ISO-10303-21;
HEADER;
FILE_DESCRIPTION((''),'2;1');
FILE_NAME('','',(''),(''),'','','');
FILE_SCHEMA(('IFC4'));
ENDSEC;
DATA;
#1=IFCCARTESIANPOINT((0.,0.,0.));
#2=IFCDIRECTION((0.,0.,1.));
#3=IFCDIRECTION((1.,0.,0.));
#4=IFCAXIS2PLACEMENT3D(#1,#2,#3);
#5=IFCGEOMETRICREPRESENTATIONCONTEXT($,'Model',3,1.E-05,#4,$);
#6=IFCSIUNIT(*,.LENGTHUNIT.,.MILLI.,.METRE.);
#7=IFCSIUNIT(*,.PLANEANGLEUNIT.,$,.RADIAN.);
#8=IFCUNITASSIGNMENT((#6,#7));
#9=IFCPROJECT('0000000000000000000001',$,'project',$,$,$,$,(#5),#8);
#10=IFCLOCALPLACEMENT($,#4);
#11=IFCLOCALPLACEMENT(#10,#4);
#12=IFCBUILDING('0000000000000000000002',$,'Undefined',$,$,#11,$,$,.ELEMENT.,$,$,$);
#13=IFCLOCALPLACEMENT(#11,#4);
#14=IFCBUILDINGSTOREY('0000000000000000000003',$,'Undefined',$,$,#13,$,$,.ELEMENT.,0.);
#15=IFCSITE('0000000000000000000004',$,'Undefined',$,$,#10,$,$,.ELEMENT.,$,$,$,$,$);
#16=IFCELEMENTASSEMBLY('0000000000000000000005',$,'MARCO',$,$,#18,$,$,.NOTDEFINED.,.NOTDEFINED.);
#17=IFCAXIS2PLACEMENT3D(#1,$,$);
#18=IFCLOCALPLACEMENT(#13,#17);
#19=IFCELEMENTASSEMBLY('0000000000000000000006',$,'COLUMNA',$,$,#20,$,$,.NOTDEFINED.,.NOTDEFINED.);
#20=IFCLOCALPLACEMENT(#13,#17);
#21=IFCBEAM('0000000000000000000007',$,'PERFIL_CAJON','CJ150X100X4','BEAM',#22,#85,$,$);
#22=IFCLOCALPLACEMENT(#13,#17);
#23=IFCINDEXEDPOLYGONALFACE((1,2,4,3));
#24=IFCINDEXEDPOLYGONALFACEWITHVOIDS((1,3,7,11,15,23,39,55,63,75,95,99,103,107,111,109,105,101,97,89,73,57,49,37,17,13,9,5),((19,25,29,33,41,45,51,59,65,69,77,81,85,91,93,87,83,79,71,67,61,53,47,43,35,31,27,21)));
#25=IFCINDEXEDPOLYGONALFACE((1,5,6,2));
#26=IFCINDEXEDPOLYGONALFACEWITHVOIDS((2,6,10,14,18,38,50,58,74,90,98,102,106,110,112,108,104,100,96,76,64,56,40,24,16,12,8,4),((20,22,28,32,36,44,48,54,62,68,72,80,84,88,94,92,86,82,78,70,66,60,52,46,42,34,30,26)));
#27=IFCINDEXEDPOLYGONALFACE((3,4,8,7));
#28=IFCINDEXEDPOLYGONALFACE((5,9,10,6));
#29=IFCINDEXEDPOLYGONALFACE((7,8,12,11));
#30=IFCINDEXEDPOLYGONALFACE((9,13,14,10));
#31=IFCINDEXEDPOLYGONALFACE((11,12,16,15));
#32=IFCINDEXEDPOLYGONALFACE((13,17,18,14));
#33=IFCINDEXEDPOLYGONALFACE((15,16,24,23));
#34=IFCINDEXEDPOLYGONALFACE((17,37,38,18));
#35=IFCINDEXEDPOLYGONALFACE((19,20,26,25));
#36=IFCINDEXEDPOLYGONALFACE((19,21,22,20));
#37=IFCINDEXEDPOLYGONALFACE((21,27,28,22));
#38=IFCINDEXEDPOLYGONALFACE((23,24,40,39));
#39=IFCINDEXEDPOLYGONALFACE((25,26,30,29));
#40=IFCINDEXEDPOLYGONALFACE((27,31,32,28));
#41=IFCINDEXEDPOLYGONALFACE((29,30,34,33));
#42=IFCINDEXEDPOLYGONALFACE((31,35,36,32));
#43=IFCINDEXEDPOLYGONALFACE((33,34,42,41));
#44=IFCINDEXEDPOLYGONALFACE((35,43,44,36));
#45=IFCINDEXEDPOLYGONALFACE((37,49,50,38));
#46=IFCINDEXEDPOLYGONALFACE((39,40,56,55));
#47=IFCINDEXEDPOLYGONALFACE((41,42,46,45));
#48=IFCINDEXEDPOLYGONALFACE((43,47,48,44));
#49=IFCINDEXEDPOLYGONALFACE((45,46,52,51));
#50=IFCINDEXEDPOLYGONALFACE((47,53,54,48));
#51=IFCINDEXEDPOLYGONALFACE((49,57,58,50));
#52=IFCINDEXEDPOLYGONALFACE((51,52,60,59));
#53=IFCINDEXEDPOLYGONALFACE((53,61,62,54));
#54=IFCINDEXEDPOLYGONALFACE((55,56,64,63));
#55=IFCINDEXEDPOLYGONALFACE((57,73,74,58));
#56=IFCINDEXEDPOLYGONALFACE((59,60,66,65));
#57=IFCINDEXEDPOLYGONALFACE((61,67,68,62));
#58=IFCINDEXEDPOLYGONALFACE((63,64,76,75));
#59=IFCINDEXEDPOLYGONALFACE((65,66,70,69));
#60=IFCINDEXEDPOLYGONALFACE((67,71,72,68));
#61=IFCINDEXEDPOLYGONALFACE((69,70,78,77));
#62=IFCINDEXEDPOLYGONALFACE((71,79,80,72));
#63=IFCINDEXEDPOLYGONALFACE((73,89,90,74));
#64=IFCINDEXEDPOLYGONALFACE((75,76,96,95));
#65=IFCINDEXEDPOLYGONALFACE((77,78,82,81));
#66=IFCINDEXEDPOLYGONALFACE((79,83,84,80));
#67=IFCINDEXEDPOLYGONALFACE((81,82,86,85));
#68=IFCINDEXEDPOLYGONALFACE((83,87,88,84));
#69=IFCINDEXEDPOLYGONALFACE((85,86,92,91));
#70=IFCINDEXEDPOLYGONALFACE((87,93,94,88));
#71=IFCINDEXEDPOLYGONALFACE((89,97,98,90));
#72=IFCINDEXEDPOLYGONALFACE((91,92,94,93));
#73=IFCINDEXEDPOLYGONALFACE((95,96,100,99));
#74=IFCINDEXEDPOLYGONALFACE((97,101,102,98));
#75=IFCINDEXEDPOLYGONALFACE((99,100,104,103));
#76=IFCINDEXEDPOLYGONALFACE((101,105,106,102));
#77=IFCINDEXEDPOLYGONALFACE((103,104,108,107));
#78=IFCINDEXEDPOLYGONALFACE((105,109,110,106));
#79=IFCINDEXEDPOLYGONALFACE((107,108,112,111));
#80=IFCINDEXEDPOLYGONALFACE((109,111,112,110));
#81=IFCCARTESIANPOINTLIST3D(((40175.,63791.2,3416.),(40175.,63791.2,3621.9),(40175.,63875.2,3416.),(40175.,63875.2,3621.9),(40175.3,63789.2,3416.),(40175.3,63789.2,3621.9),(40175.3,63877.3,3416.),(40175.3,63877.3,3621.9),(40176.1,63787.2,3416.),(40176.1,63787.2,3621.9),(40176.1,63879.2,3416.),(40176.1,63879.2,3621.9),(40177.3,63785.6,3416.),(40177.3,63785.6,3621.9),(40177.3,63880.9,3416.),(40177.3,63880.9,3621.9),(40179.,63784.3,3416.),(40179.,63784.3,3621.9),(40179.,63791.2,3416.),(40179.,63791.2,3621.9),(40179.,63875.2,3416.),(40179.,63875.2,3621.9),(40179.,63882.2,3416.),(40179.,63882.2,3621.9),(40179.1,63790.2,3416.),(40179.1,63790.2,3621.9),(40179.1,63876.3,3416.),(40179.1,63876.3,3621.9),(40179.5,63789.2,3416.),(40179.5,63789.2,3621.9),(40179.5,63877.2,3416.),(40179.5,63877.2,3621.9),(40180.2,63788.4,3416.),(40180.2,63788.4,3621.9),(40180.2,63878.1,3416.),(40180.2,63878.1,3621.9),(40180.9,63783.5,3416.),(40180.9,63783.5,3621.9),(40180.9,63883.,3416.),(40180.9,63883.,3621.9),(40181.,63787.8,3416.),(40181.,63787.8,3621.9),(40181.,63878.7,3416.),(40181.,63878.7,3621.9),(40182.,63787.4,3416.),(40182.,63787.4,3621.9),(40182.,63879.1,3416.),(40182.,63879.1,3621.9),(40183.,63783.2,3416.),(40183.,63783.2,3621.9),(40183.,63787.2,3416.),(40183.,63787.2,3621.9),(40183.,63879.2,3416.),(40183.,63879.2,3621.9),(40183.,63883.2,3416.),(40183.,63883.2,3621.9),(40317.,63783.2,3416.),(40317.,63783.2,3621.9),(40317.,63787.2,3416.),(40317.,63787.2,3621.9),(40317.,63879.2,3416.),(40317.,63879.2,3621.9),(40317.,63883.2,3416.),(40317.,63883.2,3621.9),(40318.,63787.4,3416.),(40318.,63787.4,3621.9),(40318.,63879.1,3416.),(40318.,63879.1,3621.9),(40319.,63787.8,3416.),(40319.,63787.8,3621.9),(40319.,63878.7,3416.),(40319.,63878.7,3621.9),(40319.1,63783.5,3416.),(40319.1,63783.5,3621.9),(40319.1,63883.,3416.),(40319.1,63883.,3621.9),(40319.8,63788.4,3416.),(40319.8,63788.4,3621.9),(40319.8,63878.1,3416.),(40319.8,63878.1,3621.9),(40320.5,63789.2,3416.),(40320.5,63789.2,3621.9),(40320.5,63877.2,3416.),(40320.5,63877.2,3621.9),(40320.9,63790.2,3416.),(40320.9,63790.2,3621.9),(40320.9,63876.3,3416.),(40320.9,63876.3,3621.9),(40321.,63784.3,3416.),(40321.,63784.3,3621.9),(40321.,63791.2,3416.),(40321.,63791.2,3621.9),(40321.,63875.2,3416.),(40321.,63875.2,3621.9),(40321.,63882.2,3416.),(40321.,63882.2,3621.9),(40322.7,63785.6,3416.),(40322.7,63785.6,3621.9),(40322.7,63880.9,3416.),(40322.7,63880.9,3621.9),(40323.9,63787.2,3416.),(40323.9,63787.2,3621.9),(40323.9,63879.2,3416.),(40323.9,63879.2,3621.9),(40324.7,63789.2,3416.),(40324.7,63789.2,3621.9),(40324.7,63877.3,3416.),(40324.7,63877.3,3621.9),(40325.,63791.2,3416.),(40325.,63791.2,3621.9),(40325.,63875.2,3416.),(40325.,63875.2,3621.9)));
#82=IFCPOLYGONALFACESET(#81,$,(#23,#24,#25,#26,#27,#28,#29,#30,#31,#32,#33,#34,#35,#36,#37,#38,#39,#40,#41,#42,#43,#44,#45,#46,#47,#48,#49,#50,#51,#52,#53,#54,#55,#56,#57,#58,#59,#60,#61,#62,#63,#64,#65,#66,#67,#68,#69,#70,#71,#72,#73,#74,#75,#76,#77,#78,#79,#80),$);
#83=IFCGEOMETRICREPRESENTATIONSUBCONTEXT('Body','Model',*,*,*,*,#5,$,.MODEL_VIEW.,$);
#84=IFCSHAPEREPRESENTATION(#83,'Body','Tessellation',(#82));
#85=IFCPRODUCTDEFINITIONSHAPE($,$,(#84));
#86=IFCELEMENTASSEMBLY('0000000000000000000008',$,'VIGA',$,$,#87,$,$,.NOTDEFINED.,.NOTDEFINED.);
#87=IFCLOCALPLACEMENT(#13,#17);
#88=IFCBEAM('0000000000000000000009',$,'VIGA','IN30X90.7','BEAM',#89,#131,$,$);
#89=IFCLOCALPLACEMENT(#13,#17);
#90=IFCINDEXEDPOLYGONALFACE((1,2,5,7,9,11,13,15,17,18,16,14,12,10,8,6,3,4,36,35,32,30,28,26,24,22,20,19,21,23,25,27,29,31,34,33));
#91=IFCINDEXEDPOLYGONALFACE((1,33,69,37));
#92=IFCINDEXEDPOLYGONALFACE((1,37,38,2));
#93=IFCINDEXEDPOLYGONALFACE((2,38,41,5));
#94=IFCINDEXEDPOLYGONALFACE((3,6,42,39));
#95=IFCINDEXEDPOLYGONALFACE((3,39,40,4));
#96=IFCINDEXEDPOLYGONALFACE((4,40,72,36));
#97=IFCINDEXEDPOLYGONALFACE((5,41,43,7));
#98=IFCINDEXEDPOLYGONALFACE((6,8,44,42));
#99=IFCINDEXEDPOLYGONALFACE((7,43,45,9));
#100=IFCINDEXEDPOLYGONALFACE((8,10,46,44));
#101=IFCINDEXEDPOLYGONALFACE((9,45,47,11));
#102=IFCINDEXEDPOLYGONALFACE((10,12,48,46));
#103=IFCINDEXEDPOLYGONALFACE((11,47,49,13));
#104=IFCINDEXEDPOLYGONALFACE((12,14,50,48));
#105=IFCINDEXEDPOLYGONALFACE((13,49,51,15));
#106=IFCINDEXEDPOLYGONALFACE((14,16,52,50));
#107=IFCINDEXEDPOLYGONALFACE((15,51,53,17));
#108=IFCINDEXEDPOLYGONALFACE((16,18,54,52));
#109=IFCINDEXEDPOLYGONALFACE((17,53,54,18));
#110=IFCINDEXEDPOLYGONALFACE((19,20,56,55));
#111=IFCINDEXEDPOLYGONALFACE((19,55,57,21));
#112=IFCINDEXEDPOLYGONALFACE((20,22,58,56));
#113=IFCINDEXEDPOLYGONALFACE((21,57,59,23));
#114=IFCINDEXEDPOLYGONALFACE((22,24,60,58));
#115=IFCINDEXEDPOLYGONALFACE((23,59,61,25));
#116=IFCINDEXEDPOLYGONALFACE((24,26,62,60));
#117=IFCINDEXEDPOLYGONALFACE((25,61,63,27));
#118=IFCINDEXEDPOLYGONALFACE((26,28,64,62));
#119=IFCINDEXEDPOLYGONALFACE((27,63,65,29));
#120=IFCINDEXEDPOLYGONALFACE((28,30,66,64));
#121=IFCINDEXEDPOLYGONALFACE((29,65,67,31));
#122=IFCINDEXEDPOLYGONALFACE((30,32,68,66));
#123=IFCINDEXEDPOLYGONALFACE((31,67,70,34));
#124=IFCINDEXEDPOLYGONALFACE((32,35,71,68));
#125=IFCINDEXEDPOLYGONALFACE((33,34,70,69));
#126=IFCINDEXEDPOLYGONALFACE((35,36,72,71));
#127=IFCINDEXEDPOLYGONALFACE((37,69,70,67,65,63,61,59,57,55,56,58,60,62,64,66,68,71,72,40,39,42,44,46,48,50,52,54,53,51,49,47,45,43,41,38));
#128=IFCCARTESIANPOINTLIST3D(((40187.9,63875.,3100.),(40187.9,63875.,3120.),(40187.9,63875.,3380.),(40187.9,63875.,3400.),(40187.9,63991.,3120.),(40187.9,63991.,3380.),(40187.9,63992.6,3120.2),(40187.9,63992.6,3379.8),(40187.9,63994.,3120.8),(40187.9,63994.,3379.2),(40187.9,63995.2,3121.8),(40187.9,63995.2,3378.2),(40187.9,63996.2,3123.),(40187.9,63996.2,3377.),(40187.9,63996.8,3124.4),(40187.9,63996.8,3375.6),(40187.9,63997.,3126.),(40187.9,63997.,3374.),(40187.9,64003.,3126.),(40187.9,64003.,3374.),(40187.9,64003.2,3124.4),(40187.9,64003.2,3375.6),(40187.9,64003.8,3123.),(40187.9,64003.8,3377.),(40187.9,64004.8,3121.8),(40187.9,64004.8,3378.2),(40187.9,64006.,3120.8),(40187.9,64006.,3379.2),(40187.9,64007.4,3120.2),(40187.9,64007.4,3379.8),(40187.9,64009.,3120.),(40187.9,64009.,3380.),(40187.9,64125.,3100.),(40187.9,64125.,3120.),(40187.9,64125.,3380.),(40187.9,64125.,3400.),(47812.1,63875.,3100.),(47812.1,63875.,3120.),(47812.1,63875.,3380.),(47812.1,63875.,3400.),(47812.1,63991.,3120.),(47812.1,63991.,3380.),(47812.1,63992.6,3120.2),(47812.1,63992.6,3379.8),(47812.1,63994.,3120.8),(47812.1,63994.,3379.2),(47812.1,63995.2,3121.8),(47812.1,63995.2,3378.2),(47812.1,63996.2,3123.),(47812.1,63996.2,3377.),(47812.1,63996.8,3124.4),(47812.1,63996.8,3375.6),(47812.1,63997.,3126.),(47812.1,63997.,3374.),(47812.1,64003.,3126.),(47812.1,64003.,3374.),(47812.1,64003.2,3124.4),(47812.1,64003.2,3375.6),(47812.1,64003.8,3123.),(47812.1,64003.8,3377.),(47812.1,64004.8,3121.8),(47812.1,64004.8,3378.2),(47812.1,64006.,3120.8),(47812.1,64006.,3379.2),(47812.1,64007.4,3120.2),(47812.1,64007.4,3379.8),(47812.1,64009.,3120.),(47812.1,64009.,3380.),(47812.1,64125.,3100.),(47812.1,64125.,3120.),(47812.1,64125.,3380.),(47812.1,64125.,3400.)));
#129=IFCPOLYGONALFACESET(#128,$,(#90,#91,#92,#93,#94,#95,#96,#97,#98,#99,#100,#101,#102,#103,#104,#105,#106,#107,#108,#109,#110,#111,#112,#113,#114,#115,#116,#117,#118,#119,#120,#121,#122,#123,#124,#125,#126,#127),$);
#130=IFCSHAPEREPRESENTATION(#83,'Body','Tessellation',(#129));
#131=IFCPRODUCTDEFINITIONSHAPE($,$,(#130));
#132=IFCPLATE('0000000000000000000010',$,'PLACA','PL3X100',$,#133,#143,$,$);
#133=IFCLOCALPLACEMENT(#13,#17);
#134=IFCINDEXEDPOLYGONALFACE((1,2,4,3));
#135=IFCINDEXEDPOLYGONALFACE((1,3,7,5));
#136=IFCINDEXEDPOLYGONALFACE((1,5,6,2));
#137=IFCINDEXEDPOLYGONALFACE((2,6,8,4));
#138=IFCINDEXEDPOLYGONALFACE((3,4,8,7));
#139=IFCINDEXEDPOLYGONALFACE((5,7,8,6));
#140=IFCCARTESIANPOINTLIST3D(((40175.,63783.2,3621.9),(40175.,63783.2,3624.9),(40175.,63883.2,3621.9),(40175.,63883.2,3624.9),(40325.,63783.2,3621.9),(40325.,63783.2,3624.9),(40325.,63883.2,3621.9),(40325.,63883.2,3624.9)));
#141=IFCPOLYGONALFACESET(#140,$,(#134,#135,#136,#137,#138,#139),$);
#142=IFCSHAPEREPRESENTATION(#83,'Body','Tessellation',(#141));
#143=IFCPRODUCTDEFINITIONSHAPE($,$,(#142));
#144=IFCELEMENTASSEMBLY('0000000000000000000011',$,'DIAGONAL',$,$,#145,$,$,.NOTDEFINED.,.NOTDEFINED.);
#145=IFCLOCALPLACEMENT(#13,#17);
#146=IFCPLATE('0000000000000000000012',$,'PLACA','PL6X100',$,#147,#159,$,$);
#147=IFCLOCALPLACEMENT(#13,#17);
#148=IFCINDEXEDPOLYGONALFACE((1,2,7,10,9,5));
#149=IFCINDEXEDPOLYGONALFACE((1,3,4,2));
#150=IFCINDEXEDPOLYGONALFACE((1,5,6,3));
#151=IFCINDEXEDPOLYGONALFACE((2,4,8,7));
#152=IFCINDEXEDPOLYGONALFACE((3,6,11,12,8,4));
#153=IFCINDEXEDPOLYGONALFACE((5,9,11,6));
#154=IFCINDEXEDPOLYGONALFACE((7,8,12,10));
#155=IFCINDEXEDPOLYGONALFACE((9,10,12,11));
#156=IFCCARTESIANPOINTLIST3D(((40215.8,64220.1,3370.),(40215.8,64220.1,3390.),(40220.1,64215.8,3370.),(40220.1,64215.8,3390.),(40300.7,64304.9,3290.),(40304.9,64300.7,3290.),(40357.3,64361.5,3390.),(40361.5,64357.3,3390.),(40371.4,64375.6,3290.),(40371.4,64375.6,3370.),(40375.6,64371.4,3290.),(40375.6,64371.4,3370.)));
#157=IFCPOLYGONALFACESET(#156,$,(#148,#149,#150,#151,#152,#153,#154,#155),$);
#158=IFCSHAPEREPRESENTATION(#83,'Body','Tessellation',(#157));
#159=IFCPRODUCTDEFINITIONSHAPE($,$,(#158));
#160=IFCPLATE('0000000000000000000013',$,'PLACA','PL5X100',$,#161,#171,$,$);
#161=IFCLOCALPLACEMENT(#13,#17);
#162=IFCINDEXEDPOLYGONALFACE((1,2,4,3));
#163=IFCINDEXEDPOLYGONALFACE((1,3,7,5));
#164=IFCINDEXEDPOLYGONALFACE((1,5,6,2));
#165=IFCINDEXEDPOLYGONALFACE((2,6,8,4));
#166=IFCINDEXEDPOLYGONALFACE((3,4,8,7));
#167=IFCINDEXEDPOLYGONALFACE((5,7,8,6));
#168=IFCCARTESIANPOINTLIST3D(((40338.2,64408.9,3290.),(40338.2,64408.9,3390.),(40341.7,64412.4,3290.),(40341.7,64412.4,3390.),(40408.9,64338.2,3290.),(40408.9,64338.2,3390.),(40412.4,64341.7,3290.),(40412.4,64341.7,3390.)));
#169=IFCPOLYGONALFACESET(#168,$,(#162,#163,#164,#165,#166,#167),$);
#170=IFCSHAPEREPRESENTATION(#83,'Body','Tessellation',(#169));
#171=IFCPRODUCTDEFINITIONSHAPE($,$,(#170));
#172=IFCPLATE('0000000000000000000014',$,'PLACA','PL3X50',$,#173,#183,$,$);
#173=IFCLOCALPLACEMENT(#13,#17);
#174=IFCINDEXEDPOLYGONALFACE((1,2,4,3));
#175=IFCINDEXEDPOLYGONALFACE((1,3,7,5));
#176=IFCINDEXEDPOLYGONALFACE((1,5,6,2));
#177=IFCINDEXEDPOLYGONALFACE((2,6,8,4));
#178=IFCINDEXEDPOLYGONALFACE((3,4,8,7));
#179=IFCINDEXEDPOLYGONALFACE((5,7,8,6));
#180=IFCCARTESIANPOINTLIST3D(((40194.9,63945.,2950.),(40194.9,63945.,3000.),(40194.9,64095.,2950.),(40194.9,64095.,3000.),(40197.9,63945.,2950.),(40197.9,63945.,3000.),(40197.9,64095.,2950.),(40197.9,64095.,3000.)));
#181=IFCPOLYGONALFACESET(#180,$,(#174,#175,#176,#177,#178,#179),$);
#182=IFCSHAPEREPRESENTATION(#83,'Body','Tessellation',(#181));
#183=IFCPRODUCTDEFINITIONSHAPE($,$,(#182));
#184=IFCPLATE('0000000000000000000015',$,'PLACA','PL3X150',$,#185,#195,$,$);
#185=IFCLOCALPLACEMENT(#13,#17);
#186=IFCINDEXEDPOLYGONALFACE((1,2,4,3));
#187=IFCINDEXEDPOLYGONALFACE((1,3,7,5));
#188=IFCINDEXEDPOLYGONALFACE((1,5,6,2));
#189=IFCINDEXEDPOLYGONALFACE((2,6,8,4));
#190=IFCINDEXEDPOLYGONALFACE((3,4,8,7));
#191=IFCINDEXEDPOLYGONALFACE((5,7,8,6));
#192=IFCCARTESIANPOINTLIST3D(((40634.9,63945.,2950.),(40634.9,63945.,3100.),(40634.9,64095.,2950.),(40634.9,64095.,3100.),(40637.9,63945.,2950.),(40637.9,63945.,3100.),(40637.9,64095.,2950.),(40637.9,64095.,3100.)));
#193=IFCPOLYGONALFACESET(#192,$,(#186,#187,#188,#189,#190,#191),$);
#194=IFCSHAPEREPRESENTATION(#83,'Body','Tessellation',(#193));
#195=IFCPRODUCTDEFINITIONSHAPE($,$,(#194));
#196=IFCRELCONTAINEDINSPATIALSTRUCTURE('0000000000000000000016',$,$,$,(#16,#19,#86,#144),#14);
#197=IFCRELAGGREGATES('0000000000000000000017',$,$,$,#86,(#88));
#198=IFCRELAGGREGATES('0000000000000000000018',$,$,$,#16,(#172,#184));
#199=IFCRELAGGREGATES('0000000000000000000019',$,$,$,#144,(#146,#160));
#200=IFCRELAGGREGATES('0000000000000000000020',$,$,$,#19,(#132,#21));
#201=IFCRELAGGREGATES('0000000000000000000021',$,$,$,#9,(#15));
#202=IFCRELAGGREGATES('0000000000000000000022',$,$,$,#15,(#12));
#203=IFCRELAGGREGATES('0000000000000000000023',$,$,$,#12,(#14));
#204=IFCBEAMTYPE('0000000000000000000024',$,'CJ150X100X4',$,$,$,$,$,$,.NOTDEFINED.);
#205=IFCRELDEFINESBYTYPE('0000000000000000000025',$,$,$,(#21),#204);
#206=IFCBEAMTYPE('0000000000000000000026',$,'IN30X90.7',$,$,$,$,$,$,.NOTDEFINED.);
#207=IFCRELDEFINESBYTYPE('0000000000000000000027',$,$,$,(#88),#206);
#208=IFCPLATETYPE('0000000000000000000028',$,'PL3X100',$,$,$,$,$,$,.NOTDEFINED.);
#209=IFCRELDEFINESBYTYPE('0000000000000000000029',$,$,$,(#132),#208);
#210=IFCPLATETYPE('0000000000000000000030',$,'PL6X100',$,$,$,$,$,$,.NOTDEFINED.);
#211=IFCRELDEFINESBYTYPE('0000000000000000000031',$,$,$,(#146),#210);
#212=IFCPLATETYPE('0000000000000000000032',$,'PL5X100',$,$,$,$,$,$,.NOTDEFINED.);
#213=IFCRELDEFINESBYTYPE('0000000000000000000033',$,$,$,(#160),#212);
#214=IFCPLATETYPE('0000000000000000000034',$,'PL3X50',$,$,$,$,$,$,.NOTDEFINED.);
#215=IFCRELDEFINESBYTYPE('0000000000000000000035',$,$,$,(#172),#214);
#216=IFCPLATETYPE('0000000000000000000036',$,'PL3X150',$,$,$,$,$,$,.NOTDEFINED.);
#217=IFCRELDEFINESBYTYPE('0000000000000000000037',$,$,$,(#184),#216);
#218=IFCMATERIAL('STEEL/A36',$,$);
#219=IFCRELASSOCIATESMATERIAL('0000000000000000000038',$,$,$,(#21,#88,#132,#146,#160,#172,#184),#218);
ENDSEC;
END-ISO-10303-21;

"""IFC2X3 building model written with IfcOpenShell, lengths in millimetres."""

from ifc_helpers import new_model, si_unit, frame, origin_with_axes, origin_2d_with_axis, place, context, subcontext, project, spatial, polyline, hollow_rectangle, i_section, outline, extrude, material, type_object, element, aggregate, save


model = new_model("IFC2X3")

# Units and contexts
model_context = context("Model", 3, precision=1e-05, world=origin_with_axes())
body_context = subcontext(model_context, "Body", "Model", "MODEL_VIEW")
ifc_project = project(units=[si_unit("LENGTHUNIT", "METRE", prefix="MILLI"), si_unit("PLANEANGLEUNIT", "RADIAN")], contexts=[model_context])

# Site, building, storey
site_placement = place(None, origin_with_axes())
site = spatial("IfcSite", under=ifc_project, at=site_placement, Name="Undefined", CompositionType="ELEMENT")
building_placement = place(site_placement, origin_with_axes())
building = spatial("IfcBuilding", under=site, at=building_placement, Name="Undefined", CompositionType="ELEMENT")
storey_placement = place(building_placement, origin_with_axes())
storey = spatial("IfcBuildingStorey", under=building, at=storey_placement, Name="Undefined", CompositionType="ELEMENT", Elevation=0.0)

# Element assembly
assembly_1_placement = place(storey_placement, origin_with_axes())
assembly_1 = element("IfcElementAssembly", 1, at=assembly_1_placement, inside=storey, Name="MARCO", AssemblyPlace="NOTDEFINED", PredefinedType="NOTDEFINED")
ifc_material_1 = material(Name="STEEL/A36")

# Element assemblies, beams
beam_type_1 = type_object("IfcBeamType", Name="CJ150X100X4", PredefinedType="NOTDEFINED")
assembly_2_placement = place(storey_placement, origin_with_axes())
assembly_2 = element("IfcElementAssembly", 2, at=assembly_2_placement, inside=storey, Name="COLUMNA", AssemblyPlace="NOTDEFINED", PredefinedType="NOTDEFINED")
beam_1_placement = place(assembly_2_placement, frame((40250.0, 63833.2, 3621.9), z_axis=(-1.0, 0.0, 0.0), x_axis=(0.0, 0.0, -1.0)))
beam_1 = element("IfcBeam", 3, at=beam_1_placement, type_object=beam_type_1, material=ifc_material_1, Name="PERFIL_CAJON", Description="CJ150X100X4", ObjectType="BEAM", context=body_context, shape_type="SweptSolid", body=[
    extrude(hollow_rectangle(XDim=100.0, YDim=150.0, WallThickness=4.0, InnerFilletRadius=4.0, OuterFilletRadius=8.0, at=origin_2d_with_axis()), frame((205.9, 0.0, 0.0), z_axis=(-1.0, 0.0, 0.0), x_axis=(0.0, -1.0, 0.0)), (0.0, 0.0, 1.0), 205.9),
])
assembly_3_placement = place(storey_placement, origin_with_axes())
assembly_3 = element("IfcElementAssembly", 4, at=assembly_3_placement, inside=storey, Name="VIGA", AssemblyPlace="NOTDEFINED", PredefinedType="NOTDEFINED")
beam_type_2 = type_object("IfcBeamType", Name="IN30X90.7", PredefinedType="NOTDEFINED")
beam_2_placement = place(assembly_3_placement, frame((40187.9, 64000.0, 3250.0), z_axis=(0.0, 0.0, 1.0), x_axis=(1.0, 0.0, 0.0)))
beam_2 = element("IfcBeam", 5, at=beam_2_placement, type_object=beam_type_2, material=ifc_material_1, Name="VIGA", Description="IN30X90.7", ObjectType="BEAM", context=body_context, shape_type="SweptSolid", body=[
    extrude(i_section(OverallWidth=250.0, OverallDepth=300.0, WebThickness=6.0, FlangeThickness=20.0, FilletRadius=6.0, at=origin_2d_with_axis()), frame((7624.2, 0.0, 0.0), z_axis=(-1.0, 0.0, 0.0), x_axis=(0.0, -1.0, 0.0)), (0.0, 0.0, 1.0), 7624.2),
])
aggregate(assembly_3, [beam_2])

# Plate
plate_type_1 = type_object("IfcPlateType", Name="PL3X100", PredefinedType="NOTDEFINED")
plate_1_placement = place(assembly_2_placement, frame((40325.0, 63883.2, 3623.4), z_axis=(0.0, 0.0, -1.0), x_axis=(0.0, -1.0, 0.0)))
plate_1 = element("IfcPlate", 6, at=plate_1_placement, type_object=plate_type_1, material=ifc_material_1, Name="PLACA", Description="PL3X100", context=body_context, shape_type="SweptSolid", body=[
    extrude(outline(polyline([(0.0, 0.0), (100.0, 0.0), (100.0, 150.0), (0.0, 150.0), (0.0, 0.0)])), frame((0.0, 0.0, -1.5), z_axis=(0.0, 0.0, 1.0), x_axis=(1.0, 0.0, 0.0)), (0.0, 0.0, 1.0), 3.0),
])

# Element assembly, plates
assembly_4_placement = place(storey_placement, origin_with_axes())
assembly_4 = element("IfcElementAssembly", 7, at=assembly_4_placement, inside=storey, Name="DIAGONAL", AssemblyPlace="NOTDEFINED", PredefinedType="NOTDEFINED")
plate_type_2 = type_object("IfcPlateType", Name="PL6X100", PredefinedType="NOTDEFINED")
plate_2_placement = place(assembly_4_placement, frame((40218.0, 64218.0, 3290.0), z_axis=(0.707107, -0.707107, 0.0), x_axis=(0.707107, 0.707107, 0.0)))
plate_2 = element("IfcPlate", 8, at=plate_2_placement, type_object=plate_type_2, material=ifc_material_1, Name="PLACA", Description="PL6X100", context=body_context, shape_type="SweptSolid", body=[
    extrude(outline(polyline([(0.0, 80.0), (120.0, 0.0), (220.0, 0.0), (220.0, 80.0), (200.0, 100.0), (0.0, 100.0), (0.0, 80.0)])), frame((0.0, 0.0, -3.0), z_axis=(0.0, 0.0, 1.0), x_axis=(1.0, 0.0, 0.0)), (0.0, 0.0, 1.0), 6.0),
])
plate_type_3 = type_object("IfcPlateType", Name="PL5X100", PredefinedType="NOTDEFINED")
plate_3_placement = place(assembly_4_placement, frame((40410.6, 64339.9, 3390.0), z_axis=(0.707107, 0.707107, 0.0), x_axis=(0.0, 0.0, -1.0)))
plate_3 = element("IfcPlate", 9, at=plate_3_placement, type_object=plate_type_3, material=ifc_material_1, Name="PLACA", Description="PL5X100", context=body_context, shape_type="SweptSolid", body=[
    extrude(outline(polyline([(0.0, 0.0), (100.0, 0.0), (100.0, 100.0), (0.0, 100.0), (0.0, 0.0)])), frame((0.0, 0.0, -2.5), z_axis=(0.0, 0.0, 1.0), x_axis=(1.0, 0.0, 0.0)), (0.0, 0.0, 1.0), 5.0),
])

# Plates
plate_type_4 = type_object("IfcPlateType", Name="PL3X50", PredefinedType="NOTDEFINED")
plate_4_placement = place(assembly_1_placement, frame((40196.4, 63945.0, 3000.0), z_axis=(1.0, 0.0, 0.0), x_axis=(0.0, 0.0, -1.0)))
plate_4 = element("IfcPlate", 10, at=plate_4_placement, type_object=plate_type_4, material=ifc_material_1, Name="PLACA", Description="PL3X50", context=body_context, shape_type="SweptSolid", body=[
    extrude(outline(polyline([(0.0, 0.0), (50.0, 0.0), (50.0, 150.0), (0.0, 150.0), (0.0, 0.0)])), frame((0.0, 0.0, -1.5), z_axis=(0.0, 0.0, 1.0), x_axis=(1.0, 0.0, 0.0)), (0.0, 0.0, 1.0), 3.0),
])
plate_type_5 = type_object("IfcPlateType", Name="PL3X150", PredefinedType="NOTDEFINED")
plate_5_placement = place(assembly_1_placement, frame((40636.4, 63945.0, 2950.0), z_axis=(1.0, 0.0, 0.0), x_axis=(0.0, 1.0, 0.0)))
plate_5 = element("IfcPlate", 11, at=plate_5_placement, type_object=plate_type_5, material=ifc_material_1, Name="PLACA", Description="PL3X150", context=body_context, shape_type="SweptSolid", body=[
    extrude(outline(polyline([(0.0, 0.0), (150.0, 0.0), (150.0, 150.0), (0.0, 150.0), (0.0, 0.0)])), frame((0.0, 0.0, -1.5), z_axis=(0.0, 0.0, 1.0), x_axis=(1.0, 0.0, 0.0)), (0.0, 0.0, 1.0), 3.0),
])
aggregate(assembly_1, [plate_4, plate_5])

aggregate(assembly_4, [plate_2, plate_3])
aggregate(assembly_2, [plate_1, beam_1])

save(model, "model.ifc")
